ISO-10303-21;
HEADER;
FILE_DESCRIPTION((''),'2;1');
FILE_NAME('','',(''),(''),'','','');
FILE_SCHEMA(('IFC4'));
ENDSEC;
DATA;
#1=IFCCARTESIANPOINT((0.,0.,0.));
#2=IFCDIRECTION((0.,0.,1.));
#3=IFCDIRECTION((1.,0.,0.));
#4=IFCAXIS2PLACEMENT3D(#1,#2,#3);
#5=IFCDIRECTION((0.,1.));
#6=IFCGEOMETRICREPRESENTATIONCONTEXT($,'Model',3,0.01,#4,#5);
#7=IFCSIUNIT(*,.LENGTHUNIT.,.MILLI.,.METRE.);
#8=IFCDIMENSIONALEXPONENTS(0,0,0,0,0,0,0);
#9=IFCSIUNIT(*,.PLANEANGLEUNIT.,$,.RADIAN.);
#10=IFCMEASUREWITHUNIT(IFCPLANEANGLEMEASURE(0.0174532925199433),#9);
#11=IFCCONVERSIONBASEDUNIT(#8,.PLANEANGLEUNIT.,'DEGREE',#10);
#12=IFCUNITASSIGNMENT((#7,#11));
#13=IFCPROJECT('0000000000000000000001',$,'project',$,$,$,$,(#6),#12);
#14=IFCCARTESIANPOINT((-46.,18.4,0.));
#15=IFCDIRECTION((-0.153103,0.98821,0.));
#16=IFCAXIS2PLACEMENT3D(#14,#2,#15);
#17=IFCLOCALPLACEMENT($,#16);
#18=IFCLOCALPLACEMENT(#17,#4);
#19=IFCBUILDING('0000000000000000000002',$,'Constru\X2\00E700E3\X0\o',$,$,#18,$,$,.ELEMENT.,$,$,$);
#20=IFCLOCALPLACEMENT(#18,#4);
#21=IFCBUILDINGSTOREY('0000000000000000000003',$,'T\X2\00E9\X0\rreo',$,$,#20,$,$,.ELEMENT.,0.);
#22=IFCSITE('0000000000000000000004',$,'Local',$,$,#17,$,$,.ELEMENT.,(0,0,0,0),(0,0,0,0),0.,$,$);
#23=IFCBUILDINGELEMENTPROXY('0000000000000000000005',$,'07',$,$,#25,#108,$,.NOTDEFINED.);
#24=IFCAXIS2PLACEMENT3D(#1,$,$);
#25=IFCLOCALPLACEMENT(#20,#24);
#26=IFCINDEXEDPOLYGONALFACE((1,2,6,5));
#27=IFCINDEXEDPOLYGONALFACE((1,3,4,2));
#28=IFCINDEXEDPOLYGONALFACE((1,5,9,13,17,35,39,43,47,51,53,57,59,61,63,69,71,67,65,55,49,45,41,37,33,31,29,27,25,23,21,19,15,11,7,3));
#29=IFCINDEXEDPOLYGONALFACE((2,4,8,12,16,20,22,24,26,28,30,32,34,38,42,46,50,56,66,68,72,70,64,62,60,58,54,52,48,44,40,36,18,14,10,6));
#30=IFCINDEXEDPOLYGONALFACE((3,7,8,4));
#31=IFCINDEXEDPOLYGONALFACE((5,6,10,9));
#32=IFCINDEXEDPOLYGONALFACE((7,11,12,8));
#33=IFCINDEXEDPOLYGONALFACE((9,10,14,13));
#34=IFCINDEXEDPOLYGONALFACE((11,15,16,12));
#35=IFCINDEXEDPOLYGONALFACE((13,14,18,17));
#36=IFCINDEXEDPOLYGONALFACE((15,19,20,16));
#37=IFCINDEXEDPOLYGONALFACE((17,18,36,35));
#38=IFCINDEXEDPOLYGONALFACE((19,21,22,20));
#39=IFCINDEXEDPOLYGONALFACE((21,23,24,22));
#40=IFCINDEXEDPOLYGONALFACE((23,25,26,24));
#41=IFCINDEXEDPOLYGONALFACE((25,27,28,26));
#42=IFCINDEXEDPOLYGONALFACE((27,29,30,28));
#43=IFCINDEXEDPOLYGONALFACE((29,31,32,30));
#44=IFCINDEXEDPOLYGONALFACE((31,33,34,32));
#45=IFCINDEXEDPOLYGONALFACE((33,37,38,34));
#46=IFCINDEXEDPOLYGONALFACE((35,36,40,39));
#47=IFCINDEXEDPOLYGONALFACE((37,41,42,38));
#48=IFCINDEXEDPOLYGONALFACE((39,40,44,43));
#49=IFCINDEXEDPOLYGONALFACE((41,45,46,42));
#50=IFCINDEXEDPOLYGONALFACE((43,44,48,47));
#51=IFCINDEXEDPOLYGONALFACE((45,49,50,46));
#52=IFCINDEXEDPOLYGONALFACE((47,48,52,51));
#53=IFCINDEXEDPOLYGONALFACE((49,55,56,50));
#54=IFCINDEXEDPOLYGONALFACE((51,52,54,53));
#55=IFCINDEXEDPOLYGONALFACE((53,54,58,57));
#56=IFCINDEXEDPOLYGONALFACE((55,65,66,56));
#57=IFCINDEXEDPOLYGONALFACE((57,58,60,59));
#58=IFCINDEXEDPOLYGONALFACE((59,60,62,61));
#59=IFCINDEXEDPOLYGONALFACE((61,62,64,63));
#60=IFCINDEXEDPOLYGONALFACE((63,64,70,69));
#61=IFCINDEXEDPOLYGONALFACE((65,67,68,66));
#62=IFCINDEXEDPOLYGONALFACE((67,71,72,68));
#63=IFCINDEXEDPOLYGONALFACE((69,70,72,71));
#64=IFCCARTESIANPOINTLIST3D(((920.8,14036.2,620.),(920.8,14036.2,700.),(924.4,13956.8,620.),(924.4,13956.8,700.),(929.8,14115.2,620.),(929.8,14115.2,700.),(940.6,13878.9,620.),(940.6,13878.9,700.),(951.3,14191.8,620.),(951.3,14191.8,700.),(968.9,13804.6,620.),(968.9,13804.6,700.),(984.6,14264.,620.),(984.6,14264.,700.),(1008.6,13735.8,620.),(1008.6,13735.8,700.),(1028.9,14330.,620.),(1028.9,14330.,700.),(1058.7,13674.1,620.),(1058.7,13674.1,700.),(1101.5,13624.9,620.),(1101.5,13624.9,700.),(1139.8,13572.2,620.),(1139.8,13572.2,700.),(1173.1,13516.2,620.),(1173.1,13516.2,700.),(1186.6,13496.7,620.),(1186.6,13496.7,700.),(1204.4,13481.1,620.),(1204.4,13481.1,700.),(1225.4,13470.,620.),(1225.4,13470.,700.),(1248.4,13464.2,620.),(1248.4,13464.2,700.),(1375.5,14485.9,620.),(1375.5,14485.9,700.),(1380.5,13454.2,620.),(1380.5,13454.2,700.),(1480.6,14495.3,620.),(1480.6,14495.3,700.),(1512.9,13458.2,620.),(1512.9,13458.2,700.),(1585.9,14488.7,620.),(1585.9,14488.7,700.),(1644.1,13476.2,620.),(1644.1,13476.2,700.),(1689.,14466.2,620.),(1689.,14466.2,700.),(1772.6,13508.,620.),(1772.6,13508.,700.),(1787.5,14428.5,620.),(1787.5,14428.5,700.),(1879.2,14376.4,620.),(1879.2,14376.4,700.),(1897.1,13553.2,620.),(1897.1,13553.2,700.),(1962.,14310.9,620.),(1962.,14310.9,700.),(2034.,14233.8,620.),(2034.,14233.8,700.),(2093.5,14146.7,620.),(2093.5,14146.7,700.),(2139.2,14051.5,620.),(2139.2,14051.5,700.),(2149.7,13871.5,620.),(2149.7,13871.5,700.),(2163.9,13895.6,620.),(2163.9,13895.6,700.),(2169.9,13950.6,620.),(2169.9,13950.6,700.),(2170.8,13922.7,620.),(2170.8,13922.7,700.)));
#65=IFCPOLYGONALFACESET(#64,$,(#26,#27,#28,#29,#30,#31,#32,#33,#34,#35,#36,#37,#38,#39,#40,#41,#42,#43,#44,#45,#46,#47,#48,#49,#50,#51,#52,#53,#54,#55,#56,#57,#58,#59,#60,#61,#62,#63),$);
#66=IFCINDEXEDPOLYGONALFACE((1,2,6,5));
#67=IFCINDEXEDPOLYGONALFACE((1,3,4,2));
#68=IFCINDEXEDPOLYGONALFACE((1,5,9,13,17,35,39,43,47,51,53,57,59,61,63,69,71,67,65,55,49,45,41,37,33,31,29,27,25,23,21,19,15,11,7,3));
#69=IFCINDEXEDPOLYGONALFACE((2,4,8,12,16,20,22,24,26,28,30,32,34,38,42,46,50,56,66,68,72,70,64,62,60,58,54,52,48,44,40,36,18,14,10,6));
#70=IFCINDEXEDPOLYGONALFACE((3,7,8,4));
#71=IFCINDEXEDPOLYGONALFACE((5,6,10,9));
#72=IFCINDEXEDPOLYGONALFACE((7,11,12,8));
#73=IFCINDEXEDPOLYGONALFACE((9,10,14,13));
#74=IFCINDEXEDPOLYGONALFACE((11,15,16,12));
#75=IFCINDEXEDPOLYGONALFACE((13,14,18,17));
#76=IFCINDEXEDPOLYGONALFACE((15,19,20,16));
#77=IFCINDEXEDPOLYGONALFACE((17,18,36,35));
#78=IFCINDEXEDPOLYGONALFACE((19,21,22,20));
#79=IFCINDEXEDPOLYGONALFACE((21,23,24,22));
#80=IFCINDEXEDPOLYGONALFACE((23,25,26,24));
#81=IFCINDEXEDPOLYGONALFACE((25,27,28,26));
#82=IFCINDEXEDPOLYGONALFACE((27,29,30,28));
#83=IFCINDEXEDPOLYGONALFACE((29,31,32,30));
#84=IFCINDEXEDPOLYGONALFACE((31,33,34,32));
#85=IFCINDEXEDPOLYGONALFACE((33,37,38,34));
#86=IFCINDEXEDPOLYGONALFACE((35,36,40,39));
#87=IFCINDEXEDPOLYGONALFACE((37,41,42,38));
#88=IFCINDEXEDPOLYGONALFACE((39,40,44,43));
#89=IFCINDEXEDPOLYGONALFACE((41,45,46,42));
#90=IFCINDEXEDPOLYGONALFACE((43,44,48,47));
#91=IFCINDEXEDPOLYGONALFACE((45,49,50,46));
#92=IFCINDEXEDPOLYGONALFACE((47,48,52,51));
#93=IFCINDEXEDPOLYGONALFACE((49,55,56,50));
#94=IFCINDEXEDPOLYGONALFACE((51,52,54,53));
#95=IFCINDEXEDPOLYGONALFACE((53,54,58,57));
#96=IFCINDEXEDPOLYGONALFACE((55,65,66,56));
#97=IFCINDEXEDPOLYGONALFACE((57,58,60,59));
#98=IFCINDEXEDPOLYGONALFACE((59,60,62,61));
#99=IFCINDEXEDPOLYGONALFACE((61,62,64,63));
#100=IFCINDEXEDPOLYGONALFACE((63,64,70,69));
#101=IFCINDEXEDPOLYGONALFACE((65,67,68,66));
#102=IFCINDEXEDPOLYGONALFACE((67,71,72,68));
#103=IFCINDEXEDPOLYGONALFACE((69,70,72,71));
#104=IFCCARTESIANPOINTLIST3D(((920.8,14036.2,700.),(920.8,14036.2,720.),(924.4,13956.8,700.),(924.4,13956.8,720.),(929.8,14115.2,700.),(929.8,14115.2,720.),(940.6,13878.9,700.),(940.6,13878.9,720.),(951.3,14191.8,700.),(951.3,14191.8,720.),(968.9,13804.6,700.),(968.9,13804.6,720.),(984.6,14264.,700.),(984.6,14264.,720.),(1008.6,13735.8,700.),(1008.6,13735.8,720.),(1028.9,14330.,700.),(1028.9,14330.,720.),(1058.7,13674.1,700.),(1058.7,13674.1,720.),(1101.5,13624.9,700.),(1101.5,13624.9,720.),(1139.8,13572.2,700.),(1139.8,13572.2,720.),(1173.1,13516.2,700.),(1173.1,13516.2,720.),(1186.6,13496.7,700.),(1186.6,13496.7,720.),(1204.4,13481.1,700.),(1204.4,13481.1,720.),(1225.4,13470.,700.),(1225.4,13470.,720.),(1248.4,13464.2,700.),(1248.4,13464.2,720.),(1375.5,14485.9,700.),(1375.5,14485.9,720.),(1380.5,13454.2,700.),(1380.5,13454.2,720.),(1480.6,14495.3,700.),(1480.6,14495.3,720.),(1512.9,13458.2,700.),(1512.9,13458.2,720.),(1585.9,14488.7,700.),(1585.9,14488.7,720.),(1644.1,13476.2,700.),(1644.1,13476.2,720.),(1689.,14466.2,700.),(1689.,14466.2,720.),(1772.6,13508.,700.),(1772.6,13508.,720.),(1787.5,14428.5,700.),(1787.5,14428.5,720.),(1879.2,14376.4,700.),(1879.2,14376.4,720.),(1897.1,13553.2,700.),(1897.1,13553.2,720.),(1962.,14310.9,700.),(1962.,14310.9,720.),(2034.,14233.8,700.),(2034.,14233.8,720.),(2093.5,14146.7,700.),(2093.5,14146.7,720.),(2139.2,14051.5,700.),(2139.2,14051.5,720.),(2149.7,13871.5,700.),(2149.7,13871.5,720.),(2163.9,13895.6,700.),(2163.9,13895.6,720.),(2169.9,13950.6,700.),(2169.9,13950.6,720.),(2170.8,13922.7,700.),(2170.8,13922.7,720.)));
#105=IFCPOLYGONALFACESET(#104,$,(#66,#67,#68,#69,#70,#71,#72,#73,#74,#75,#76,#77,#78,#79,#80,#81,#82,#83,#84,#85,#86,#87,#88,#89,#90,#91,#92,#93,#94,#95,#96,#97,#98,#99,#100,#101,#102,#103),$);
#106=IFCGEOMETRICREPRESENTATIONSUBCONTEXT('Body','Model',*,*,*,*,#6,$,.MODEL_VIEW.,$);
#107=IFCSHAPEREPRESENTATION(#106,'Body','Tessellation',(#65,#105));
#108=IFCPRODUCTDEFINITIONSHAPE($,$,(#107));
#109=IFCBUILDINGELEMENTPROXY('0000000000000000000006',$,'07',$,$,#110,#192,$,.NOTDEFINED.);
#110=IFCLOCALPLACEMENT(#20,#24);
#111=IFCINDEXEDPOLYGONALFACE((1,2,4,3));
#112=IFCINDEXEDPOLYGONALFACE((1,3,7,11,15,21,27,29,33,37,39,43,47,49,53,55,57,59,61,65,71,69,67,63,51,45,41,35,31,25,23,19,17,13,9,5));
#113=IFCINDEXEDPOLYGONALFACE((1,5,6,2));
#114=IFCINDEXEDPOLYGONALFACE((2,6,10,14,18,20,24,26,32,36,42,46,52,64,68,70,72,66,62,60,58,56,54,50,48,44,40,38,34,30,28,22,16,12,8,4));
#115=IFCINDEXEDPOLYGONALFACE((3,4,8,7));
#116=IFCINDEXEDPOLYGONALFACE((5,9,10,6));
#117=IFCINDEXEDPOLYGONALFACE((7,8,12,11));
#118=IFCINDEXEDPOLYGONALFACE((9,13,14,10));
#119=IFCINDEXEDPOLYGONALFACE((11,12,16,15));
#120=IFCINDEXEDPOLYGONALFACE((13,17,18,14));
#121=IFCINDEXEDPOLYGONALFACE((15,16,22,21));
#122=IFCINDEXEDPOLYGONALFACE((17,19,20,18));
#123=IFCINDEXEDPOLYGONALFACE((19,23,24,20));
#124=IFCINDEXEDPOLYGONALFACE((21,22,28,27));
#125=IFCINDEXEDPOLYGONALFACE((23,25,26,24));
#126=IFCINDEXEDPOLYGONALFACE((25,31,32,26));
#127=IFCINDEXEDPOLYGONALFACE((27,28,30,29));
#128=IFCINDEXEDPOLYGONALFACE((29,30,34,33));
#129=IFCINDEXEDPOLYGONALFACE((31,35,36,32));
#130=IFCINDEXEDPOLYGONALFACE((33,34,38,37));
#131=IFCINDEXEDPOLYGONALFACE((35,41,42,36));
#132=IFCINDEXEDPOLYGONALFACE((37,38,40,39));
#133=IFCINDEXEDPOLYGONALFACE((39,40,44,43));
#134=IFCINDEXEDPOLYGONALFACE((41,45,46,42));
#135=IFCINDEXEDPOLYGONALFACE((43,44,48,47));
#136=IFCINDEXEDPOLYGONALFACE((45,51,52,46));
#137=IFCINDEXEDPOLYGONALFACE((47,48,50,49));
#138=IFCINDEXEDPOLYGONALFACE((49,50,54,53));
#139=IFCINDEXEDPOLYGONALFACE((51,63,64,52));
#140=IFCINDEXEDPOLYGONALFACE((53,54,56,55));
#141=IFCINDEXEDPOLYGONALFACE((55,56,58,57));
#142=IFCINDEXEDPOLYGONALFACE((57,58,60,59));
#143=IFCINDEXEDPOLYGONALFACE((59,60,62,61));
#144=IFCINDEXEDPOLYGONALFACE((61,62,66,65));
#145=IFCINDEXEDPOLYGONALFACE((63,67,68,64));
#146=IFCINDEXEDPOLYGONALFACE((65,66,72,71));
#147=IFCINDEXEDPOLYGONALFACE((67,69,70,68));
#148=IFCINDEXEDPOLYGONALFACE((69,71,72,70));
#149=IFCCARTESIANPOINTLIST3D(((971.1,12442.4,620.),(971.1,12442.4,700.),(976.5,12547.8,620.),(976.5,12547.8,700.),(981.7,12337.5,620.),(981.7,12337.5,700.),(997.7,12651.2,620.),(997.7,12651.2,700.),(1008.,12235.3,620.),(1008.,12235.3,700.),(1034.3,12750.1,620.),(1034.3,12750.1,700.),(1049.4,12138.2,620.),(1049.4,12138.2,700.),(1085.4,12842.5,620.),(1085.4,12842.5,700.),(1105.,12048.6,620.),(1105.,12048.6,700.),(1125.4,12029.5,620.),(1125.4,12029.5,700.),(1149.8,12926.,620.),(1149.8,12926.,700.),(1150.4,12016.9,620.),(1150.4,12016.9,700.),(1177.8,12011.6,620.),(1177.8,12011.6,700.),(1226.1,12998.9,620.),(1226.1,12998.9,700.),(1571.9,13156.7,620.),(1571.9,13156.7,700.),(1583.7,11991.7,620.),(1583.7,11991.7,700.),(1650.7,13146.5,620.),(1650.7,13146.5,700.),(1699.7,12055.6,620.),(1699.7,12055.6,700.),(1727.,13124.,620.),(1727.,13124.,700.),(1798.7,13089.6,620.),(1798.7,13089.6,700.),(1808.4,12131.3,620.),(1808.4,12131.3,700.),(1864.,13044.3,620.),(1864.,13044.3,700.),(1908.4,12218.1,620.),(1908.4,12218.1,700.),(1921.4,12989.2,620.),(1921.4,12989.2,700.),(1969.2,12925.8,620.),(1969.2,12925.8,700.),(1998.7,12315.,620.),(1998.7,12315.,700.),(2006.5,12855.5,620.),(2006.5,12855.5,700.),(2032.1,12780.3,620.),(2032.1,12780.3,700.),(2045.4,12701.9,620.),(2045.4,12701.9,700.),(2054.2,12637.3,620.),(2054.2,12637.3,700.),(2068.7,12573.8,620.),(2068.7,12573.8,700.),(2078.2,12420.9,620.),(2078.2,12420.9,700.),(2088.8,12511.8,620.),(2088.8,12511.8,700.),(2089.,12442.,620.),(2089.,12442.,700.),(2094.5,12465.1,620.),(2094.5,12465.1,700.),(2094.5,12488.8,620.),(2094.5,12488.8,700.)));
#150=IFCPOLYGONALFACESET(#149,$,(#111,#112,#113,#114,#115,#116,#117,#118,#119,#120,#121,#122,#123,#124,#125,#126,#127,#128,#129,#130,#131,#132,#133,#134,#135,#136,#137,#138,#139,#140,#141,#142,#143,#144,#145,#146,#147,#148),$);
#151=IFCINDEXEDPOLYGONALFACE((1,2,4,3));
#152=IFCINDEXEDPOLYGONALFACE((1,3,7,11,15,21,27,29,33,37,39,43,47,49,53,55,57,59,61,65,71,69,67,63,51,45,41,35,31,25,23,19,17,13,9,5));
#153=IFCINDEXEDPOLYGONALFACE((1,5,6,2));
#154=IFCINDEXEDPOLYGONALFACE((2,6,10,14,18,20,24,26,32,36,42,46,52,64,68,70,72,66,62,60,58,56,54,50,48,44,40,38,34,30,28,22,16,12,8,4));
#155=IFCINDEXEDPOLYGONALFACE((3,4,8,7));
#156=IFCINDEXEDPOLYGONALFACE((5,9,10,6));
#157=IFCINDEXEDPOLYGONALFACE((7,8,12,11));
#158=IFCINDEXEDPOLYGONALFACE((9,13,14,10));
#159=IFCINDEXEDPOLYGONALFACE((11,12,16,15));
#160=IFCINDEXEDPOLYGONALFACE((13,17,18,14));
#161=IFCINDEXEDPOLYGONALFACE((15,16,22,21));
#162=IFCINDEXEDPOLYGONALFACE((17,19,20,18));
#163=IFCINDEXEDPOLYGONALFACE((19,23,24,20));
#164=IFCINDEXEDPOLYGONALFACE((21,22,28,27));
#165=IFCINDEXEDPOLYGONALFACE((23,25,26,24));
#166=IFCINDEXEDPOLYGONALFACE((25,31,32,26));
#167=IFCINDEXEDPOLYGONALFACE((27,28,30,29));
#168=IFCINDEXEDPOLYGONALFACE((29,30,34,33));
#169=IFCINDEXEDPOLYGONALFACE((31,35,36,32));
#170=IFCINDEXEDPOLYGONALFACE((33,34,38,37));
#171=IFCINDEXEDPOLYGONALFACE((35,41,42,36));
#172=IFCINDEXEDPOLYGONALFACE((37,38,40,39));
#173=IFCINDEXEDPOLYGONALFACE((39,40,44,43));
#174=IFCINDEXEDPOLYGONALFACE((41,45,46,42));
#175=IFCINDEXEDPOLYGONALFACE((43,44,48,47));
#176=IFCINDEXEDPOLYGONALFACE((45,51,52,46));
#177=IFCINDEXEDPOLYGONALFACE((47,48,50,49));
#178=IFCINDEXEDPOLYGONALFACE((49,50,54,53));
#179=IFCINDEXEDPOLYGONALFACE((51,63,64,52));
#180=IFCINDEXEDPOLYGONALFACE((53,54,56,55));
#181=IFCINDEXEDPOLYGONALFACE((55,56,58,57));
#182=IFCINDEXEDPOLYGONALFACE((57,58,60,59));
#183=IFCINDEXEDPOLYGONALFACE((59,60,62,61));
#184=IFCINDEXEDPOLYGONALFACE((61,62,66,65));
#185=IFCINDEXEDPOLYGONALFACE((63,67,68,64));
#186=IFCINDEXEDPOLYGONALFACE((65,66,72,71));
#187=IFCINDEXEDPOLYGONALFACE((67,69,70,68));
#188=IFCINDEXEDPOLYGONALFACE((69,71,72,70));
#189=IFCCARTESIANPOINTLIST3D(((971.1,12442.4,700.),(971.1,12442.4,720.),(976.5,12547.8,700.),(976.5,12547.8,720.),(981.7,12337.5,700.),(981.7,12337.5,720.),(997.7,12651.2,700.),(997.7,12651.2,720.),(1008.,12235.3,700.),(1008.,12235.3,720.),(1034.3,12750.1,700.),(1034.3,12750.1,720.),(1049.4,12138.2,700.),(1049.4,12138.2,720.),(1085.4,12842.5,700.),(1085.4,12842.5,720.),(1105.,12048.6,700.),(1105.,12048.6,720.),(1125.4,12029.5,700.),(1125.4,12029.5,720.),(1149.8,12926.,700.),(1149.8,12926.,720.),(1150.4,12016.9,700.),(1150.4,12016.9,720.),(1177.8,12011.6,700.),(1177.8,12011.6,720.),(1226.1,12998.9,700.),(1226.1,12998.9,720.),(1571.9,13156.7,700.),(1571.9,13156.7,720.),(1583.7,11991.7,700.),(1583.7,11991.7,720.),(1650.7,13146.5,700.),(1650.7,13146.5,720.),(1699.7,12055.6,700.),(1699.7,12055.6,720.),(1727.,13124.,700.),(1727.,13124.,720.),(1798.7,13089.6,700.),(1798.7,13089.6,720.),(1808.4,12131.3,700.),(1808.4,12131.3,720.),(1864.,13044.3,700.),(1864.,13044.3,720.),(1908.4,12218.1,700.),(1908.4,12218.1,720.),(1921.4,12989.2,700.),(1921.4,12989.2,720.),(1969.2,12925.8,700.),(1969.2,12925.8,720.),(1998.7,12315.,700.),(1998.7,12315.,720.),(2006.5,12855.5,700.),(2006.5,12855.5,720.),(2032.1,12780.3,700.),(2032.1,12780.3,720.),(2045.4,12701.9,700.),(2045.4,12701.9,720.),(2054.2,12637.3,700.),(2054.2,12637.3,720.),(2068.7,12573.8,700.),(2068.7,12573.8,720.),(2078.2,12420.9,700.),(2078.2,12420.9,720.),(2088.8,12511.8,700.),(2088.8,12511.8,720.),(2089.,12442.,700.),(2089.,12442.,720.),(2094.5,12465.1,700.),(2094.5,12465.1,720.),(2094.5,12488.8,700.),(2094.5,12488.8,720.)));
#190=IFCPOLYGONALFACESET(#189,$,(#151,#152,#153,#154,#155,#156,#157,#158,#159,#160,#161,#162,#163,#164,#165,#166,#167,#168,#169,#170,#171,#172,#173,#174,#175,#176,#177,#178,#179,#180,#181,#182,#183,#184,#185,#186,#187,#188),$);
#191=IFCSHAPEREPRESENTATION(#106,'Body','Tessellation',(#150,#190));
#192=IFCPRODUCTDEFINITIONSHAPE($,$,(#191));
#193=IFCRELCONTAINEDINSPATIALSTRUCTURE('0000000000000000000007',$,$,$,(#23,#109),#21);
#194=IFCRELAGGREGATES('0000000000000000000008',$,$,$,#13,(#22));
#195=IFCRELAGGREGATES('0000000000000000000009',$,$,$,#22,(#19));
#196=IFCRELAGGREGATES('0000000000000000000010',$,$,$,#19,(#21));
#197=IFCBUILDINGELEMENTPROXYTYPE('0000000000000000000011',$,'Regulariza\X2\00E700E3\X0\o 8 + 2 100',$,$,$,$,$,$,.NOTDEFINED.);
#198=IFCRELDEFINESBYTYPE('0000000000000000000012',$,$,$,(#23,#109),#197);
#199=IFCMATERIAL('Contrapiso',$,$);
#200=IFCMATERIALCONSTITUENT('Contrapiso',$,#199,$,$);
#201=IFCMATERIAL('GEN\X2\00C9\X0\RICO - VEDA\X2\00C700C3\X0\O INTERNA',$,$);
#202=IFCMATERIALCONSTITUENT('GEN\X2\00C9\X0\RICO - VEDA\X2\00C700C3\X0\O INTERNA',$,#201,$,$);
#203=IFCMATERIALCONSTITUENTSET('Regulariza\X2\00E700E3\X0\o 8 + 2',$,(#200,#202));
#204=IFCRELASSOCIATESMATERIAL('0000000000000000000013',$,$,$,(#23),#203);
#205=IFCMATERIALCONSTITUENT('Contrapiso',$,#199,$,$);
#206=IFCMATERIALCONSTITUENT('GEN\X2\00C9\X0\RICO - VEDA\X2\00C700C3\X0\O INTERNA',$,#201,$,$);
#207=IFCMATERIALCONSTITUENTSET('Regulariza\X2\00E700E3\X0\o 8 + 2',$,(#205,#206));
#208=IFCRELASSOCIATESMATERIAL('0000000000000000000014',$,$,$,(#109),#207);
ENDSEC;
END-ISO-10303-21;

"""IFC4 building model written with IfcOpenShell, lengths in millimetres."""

from ifc_helpers import new_model, entity, si_unit, converted_unit, direction, frame, origin_with_axes, place, context, subcontext, project, spatial, line, arc, indexed_curve, outline, extrude, material, constituent, constituent_set, type_object, element, save


model = new_model("IFC4")

# Units and contexts
model_context = context("Model", 3, precision=0.01, world=origin_with_axes(), true_north=direction((0.0, 1.0)))
body_context = subcontext(model_context, "Body", "Model", "MODEL_VIEW")
ifc_project = project(units=[si_unit("LENGTHUNIT", "METRE", prefix="MILLI"), converted_unit("PLANEANGLEUNIT", "DEGREE", entity("IfcPlaneAngleMeasure", 0.0174532925199433), si_unit("PLANEANGLEUNIT", "RADIAN"), dimensions=[0, 0, 0, 0, 0, 0, 0])], contexts=[model_context])

# Site, building, storey
site_placement = place(None, frame((-46.0, 18.4, 0.0), z_axis=(0.0, 0.0, 1.0), x_axis=(-0.153103, 0.98821, 0.0)))
site = spatial("IfcSite", under=ifc_project, at=site_placement, Name="Local", CompositionType="ELEMENT", RefLatitude=(0, 0, 0, 0), RefLongitude=(0, 0, 0, 0), RefElevation=0.0)
building_placement = place(site_placement, origin_with_axes())
building = spatial("IfcBuilding", under=site, at=building_placement, Name="Construção", CompositionType="ELEMENT")
storey_placement = place(building_placement, origin_with_axes())
storey = spatial("IfcBuildingStorey", under=building, at=storey_placement, Name="Térreo", CompositionType="ELEMENT", Elevation=0.0)

# Shared definitions
ifc_material_1 = material(Name="GENÉRICO - VEDAÇÃO INTERNA")

# Building element proxies
ifc_material_2 = material(Name="Contrapiso")
building_element_proxy_type_1 = type_object("IfcBuildingElementProxyType", Name="Regularização 8 + 2 100", PredefinedType="NOTDEFINED")
ifc_constituent_1 = constituent(ifc_material_2, Name="Contrapiso")
ifc_constituent_2 = constituent(ifc_material_1, Name="GENÉRICO - VEDAÇÃO INTERNA")
ifc_constituent_set_1 = constituent_set(constituents=[ifc_constituent_1, ifc_constituent_2], Name="Regularização 8 + 2")
proxy_1_placement = place(storey_placement, frame((1375.5, 14485.9, 720.0), z_axis=(0.0, 0.0, 1.0), x_axis=(1.0, 0.0, 0.0)))
element("IfcBuildingElementProxy", 1, at=proxy_1_placement, inside=storey, type_object=building_element_proxy_type_1, material=ifc_constituent_set_1, Name="07", PredefinedType="NOTDEFINED", context=body_context, shape_type="SweptSolid", body=[
    extrude(outline(indexed_curve([(0.0, 0.0), (-346.6, -155.9), (-454.4, -489.5), (-316.7, -811.9), (-254.2, -886.9), (-202.4, -969.7), (-171.0, -1004.9), (-127.0, -1021.7), (203.2, -1020.4), (521.7, -932.7), (774.3, -614.4), (792.8, -577.0), (794.5, -535.3), (503.8, -109.6)], segments=[line(1, 2), arc(2, 3, 4), arc(4, 5, 6), arc(6, 7, 8), arc(8, 9, 10), line(10, 11), arc(11, 12, 13), arc(13, 14, 1)])), frame((0.0, 0.0, -100.0), z_axis=(0.0, 0.0, 1.0), x_axis=(1.0, 0.0, 0.0)), (0.0, 0.0, 1.0), 80.0),
    extrude(outline(indexed_curve([(0.0, 0.0), (-346.6, -155.9), (-454.4, -489.5), (-316.7, -811.9), (-254.2, -886.9), (-202.4, -969.7), (-171.0, -1004.9), (-127.0, -1021.7), (203.2, -1020.4), (521.7, -932.7), (774.3, -614.4), (792.8, -577.0), (794.5, -535.3), (503.8, -109.6)], segments=[line(1, 2), arc(2, 3, 4), arc(4, 5, 6), arc(6, 7, 8), arc(8, 9, 10), line(10, 11), arc(11, 12, 13), arc(13, 14, 1)])), frame((0.0, 0.0, -20.0), z_axis=(0.0, 0.0, 1.0), x_axis=(1.0, 0.0, 0.0)), (0.0, 0.0, 1.0), 20.0),
])
ifc_constituent_3 = constituent(ifc_material_2, Name="Contrapiso")
ifc_constituent_4 = constituent(ifc_material_1, Name="GENÉRICO - VEDAÇÃO INTERNA")
ifc_constituent_set_2 = constituent_set(constituents=[ifc_constituent_3, ifc_constituent_4], Name="Regularização 8 + 2")
proxy_2_placement = place(storey_placement, frame((1226.1, 12998.9, 720.0), z_axis=(0.0, 0.0, 1.0), x_axis=(1.0, 0.0, 0.0)))
element("IfcBuildingElementProxy", 2, at=proxy_2_placement, inside=storey, type_object=building_element_proxy_type_1, material=ifc_constituent_set_2, Name="07", PredefinedType="NOTDEFINED", context=body_context, shape_type="SweptSolid", body=[
    extrude(outline(indexed_curve([(0.0, 0.0), (-249.7, -451.0), (-121.2, -950.3), (-88.7, -976.5), (-48.3, -987.2), (357.6, -1007.1), (633.4, -825.4), (852.1, -577.9), (868.4, -533.8), (862.7, -487.0), (834.5, -393.5), (819.3, -297.0), (667.6, 19.1), (345.7, 157.8)], segments=[arc(1, 2, 3), arc(3, 4, 5), line(5, 6), arc(6, 7, 8), arc(8, 9, 10), arc(10, 11, 12), arc(12, 13, 14), line(14, 1)])), frame((0.0, 0.0, -100.0), z_axis=(0.0, 0.0, 1.0), x_axis=(1.0, 0.0, 0.0)), (0.0, 0.0, 1.0), 80.0),
    extrude(outline(indexed_curve([(0.0, 0.0), (-249.7, -451.0), (-121.2, -950.3), (-88.7, -976.5), (-48.3, -987.2), (357.6, -1007.1), (633.4, -825.4), (852.1, -577.9), (868.4, -533.8), (862.7, -487.0), (834.5, -393.5), (819.3, -297.0), (667.6, 19.1), (345.7, 157.8)], segments=[arc(1, 2, 3), arc(3, 4, 5), line(5, 6), arc(6, 7, 8), arc(8, 9, 10), arc(10, 11, 12), arc(12, 13, 14), line(14, 1)])), frame((0.0, 0.0, -20.0), z_axis=(0.0, 0.0, 1.0), x_axis=(1.0, 0.0, 0.0)), (0.0, 0.0, 1.0), 20.0),
])

save(model, "model.ifc")
